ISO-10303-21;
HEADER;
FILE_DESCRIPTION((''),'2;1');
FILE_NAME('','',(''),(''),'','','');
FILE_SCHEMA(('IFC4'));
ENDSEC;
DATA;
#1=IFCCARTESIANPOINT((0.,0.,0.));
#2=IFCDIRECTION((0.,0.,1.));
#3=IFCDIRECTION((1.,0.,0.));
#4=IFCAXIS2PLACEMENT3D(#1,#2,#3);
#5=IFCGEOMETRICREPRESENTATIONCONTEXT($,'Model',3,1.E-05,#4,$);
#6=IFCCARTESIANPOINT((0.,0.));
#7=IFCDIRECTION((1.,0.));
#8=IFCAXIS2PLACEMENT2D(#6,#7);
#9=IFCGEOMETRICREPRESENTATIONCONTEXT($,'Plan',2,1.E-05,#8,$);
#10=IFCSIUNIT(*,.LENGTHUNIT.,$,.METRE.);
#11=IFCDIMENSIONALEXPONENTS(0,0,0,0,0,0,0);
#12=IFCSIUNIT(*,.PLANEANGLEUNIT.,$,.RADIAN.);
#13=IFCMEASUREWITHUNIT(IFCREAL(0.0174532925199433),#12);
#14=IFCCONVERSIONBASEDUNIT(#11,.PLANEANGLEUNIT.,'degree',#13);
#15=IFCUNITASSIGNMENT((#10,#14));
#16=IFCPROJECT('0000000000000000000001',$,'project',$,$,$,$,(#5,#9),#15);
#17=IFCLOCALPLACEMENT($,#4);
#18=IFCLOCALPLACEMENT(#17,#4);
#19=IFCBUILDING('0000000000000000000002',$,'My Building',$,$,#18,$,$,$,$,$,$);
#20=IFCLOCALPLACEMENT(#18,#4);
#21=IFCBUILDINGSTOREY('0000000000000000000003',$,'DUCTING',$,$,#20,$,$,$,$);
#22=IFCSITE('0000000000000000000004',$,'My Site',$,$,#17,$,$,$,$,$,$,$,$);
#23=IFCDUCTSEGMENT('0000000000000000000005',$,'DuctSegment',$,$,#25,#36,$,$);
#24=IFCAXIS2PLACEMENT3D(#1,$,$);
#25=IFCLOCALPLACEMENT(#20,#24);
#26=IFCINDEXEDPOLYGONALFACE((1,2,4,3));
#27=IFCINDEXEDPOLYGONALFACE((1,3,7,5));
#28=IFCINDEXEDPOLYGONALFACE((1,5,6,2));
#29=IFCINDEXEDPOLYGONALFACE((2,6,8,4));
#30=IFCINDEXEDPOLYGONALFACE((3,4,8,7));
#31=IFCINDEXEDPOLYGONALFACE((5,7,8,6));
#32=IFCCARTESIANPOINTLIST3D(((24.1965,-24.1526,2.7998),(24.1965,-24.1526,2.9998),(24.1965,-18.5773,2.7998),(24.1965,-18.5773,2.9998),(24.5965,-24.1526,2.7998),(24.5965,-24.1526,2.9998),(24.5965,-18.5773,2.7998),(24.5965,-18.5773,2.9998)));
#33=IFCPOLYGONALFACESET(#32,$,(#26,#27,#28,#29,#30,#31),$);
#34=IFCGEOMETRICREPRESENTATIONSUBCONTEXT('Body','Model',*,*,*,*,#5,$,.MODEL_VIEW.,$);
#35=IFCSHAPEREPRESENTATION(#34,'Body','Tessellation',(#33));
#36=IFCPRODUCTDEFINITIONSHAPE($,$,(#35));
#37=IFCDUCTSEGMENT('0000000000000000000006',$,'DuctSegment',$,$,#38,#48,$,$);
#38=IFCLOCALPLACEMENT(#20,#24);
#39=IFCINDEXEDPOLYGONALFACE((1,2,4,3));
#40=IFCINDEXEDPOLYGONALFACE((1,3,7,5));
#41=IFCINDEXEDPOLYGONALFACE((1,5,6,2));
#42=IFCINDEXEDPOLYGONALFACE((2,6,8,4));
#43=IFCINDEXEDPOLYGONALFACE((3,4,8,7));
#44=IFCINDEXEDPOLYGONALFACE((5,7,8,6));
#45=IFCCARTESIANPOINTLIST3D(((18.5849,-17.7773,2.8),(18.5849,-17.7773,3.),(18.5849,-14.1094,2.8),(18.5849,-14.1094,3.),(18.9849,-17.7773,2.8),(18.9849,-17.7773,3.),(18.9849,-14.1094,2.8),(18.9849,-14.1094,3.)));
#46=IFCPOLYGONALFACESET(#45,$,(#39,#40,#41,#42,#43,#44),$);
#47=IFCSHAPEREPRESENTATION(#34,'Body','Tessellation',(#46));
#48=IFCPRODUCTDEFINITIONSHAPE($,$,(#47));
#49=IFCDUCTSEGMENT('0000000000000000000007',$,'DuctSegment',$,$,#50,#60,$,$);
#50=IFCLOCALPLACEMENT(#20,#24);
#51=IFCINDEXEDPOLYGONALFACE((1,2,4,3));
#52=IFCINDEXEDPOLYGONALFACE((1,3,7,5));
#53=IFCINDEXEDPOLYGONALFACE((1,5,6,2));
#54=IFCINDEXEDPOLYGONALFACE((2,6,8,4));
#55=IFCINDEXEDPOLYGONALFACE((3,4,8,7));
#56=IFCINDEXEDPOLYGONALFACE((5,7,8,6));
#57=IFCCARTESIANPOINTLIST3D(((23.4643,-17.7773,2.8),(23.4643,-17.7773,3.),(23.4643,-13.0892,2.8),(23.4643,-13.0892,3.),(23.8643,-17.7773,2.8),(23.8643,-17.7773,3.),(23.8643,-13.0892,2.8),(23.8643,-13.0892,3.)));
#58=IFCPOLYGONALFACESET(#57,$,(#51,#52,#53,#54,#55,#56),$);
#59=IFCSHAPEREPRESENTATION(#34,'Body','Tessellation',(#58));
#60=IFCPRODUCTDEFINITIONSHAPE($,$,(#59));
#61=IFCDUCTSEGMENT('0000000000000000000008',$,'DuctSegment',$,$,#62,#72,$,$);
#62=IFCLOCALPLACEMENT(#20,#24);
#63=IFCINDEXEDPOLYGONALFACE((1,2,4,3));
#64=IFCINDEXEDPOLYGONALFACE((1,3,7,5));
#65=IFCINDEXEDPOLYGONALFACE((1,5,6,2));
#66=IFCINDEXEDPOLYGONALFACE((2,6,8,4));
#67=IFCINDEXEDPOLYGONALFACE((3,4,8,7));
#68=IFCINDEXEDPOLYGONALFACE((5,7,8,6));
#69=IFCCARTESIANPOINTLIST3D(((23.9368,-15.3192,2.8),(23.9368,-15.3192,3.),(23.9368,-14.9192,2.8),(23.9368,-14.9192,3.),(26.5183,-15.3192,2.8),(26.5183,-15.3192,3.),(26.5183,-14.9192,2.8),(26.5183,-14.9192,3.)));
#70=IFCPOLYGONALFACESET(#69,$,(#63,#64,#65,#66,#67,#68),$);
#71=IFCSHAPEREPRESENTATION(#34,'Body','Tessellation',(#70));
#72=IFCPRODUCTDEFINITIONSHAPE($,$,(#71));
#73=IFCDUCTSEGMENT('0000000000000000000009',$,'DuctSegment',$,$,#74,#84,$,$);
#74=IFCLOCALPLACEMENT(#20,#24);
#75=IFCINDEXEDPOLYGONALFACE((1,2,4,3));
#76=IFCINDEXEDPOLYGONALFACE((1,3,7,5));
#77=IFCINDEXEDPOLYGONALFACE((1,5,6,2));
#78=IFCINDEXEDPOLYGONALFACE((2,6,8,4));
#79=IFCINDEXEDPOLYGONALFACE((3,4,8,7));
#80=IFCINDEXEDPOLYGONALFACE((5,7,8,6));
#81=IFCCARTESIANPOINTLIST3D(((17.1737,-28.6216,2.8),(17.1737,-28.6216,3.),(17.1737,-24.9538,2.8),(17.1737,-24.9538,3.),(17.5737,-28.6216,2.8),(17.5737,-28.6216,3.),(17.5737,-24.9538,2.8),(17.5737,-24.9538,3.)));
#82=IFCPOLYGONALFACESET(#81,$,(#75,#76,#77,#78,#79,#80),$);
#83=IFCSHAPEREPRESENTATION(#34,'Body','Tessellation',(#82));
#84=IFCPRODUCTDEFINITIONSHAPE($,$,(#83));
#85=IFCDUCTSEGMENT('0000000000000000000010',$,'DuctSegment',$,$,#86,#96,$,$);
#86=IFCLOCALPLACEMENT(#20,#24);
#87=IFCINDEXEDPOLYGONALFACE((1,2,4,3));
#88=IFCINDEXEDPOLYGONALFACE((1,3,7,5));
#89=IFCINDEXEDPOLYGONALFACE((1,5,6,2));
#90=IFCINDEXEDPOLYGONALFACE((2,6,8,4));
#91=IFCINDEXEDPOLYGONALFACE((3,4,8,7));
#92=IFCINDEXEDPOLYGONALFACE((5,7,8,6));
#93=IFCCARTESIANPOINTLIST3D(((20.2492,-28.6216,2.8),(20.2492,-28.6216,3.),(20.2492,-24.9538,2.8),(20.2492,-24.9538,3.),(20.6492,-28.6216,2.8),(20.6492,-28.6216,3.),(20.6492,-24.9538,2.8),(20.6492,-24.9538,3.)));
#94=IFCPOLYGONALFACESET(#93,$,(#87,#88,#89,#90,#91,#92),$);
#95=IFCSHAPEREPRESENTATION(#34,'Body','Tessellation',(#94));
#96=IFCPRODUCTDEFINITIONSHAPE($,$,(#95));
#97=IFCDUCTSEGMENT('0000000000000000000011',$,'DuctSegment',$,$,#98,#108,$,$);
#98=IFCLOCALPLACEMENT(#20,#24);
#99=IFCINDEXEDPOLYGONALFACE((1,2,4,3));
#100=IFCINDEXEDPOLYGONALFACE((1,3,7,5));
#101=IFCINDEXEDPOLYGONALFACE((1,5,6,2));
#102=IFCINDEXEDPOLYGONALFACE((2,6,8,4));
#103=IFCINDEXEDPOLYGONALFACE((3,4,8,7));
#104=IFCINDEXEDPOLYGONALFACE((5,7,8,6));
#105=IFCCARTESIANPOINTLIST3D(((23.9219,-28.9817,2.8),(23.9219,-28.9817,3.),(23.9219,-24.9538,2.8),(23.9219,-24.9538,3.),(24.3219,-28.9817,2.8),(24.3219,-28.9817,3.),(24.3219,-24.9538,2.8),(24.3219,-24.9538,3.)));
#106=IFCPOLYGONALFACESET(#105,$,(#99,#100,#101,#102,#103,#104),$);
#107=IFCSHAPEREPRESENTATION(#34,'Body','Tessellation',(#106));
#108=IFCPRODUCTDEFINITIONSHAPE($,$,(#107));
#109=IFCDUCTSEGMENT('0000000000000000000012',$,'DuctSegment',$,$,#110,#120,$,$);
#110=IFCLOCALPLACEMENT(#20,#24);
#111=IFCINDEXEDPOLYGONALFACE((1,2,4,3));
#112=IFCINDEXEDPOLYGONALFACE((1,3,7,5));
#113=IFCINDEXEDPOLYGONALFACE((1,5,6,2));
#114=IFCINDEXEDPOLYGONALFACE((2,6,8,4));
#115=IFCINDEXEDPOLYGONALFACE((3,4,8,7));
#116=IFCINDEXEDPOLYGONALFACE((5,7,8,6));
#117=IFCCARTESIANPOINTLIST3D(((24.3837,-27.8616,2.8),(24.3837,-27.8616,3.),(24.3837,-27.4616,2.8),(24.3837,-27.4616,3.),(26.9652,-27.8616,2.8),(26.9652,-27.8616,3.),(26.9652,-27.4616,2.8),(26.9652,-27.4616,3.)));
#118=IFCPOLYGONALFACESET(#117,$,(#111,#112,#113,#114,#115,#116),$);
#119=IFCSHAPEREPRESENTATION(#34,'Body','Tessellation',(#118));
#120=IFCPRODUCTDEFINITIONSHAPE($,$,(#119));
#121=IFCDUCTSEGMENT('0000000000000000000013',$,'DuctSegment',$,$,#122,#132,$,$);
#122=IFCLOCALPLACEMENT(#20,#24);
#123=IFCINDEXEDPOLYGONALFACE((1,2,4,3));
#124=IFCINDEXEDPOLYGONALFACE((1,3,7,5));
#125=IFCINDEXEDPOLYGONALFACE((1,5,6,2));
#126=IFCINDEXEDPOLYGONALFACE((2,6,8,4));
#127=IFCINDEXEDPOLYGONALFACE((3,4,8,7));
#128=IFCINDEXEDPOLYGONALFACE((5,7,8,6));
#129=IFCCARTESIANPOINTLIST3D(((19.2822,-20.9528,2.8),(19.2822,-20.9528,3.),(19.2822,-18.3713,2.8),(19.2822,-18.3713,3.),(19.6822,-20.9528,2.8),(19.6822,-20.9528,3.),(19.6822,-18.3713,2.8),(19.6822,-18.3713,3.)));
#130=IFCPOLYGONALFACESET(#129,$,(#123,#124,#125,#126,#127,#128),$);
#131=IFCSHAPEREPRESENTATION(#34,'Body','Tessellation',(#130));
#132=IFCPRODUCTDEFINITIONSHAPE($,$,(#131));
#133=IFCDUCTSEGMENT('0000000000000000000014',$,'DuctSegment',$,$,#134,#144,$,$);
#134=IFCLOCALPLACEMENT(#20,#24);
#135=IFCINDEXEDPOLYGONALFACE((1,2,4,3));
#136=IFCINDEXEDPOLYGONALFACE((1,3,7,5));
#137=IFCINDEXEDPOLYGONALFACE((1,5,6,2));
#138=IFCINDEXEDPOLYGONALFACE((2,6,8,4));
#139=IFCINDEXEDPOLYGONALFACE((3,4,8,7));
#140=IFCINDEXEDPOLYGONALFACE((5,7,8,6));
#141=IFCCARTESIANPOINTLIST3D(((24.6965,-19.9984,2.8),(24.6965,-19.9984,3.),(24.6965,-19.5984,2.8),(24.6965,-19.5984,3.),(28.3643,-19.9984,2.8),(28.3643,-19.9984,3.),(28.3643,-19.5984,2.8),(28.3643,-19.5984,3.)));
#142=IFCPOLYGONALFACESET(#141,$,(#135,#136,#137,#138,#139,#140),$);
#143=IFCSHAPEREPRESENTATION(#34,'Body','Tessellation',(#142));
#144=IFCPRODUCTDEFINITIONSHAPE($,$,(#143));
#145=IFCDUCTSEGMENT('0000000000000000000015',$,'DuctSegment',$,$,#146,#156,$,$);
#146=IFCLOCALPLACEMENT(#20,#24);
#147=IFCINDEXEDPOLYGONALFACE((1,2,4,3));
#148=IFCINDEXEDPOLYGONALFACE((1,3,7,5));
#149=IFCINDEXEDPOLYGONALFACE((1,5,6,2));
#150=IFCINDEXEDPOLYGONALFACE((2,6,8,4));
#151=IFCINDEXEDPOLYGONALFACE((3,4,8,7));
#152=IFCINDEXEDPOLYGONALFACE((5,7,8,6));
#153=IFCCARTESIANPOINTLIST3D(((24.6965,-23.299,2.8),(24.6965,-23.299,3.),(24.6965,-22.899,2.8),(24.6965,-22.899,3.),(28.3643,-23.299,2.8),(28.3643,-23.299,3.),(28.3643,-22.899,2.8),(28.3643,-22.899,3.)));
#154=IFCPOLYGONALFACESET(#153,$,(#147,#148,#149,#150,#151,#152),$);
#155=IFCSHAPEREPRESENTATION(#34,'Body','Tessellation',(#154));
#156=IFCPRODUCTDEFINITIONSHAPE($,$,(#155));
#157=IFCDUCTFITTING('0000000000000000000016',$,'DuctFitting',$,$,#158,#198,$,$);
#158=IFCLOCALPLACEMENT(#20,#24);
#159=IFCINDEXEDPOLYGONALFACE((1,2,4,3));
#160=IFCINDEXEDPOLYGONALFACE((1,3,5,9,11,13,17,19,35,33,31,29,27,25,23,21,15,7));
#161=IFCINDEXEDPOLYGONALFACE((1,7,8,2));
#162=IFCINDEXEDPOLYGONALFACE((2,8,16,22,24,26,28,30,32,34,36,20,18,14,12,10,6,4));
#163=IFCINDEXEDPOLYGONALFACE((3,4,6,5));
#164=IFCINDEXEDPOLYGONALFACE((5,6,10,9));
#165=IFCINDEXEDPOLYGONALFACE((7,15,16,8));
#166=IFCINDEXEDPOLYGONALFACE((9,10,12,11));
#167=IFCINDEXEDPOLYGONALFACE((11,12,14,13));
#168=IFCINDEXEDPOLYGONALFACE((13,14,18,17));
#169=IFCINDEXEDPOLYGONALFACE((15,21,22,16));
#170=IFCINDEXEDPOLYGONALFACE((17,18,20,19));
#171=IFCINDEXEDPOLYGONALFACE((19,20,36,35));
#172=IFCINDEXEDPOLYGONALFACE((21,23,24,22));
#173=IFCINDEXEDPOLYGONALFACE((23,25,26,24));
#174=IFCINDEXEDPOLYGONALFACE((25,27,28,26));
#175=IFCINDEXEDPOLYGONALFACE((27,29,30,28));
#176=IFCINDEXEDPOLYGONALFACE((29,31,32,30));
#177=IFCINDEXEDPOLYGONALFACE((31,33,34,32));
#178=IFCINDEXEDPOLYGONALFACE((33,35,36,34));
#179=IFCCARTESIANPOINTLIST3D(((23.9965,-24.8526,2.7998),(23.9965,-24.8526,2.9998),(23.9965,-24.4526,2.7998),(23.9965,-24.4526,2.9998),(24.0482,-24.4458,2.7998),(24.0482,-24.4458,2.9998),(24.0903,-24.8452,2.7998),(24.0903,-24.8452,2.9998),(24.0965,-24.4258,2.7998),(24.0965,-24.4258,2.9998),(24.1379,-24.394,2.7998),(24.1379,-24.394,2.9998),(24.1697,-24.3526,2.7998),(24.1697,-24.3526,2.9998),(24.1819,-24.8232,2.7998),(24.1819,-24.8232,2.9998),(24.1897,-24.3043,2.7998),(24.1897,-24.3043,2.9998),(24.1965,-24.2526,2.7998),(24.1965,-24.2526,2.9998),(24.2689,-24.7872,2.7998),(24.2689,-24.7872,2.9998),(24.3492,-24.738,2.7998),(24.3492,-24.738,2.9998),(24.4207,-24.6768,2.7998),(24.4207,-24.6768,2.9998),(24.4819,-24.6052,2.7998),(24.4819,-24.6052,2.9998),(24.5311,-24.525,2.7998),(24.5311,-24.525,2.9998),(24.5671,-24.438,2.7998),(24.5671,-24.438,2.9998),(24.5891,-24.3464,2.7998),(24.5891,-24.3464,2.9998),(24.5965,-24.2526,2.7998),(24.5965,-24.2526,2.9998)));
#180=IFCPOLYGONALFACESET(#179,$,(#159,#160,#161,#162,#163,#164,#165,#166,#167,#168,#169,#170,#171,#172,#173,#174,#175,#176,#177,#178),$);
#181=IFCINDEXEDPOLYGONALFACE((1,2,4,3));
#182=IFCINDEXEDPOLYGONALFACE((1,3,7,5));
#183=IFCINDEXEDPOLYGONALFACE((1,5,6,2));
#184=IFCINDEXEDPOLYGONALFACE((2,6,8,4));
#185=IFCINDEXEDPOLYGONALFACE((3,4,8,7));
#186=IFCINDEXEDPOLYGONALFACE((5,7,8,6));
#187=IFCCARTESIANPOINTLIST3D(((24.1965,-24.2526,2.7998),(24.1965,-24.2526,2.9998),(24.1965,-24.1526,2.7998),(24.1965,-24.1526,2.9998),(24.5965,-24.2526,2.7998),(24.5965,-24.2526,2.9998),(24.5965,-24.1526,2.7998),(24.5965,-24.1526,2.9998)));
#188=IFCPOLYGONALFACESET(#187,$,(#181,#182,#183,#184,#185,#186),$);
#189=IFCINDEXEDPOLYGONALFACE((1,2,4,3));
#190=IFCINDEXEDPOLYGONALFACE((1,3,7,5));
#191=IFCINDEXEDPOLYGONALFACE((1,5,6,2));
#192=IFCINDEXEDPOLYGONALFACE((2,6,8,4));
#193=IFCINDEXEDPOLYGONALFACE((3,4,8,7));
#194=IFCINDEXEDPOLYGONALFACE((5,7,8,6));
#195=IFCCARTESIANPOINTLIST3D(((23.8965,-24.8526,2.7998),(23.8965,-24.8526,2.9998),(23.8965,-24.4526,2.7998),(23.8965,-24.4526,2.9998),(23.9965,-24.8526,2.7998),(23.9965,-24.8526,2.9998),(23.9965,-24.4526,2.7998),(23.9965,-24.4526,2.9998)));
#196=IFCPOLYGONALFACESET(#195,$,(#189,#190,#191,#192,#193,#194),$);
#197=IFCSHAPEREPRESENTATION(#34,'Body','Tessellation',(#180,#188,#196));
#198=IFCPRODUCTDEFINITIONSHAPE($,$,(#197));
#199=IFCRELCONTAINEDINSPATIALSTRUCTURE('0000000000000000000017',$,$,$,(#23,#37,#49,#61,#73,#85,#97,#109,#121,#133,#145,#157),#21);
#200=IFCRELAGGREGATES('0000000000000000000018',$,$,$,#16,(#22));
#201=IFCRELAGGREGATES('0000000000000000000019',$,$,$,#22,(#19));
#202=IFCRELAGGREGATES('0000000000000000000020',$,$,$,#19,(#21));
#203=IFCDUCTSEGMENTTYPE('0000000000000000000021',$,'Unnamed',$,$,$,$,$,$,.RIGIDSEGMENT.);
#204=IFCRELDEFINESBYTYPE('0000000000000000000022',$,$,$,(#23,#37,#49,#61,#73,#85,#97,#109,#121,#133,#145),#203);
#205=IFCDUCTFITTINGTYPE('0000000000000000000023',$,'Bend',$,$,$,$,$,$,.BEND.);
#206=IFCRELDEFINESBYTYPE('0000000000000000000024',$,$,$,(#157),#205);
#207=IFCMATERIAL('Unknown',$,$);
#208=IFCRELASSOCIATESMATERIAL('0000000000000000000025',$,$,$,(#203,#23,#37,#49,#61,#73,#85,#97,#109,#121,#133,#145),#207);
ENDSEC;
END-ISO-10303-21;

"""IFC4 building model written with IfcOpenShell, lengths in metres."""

from ifc_helpers import new_model, entity, si_unit, converted_unit, frame, origin_with_axes, origin_2d_with_axis, place, context, subcontext, project, spatial, line, arc, indexed_curve, rectangle, outline, extrude, source, transform, mapped, material, material_profile, profile_set, profile_usage, type_object, type_shapes, element, save


model = new_model("IFC4")

# Units and contexts
model_context = context("Model", 3, precision=1e-05, world=origin_with_axes())
plan_context = context("Plan", 2, precision=1e-05, world=origin_2d_with_axis())
body_context = subcontext(model_context, "Body", "Model", "MODEL_VIEW")
ifc_project = project(units=[si_unit("LENGTHUNIT", "METRE"), converted_unit("PLANEANGLEUNIT", "degree", entity("IfcReal", 0.0174532925199433), si_unit("PLANEANGLEUNIT", "RADIAN"), dimensions=[0, 0, 0, 0, 0, 0, 0])], contexts=[model_context, plan_context])

# Site, building, storey
site_placement = place(None, origin_with_axes())
site = spatial("IfcSite", under=ifc_project, at=site_placement, Name="My Site")
building_placement = place(site_placement, origin_with_axes())
building = spatial("IfcBuilding", under=site, at=building_placement, Name="My Building")
storey_placement = place(building_placement, origin_with_axes())
storey = spatial("IfcBuildingStorey", under=building, at=storey_placement, Name="DUCTING")

# Duct segments
ifc_material = material(Name="Unknown")
ifc_material_profile_1 = material_profile(ifc_material, rectangle(XDim=0.4, YDim=0.2))
ifc_profile_set_1 = profile_set([ifc_material_profile_1])
ifc_profile_usage_1 = profile_usage(ifc_profile_set_1, cardinal=5)
duct_segment_type = type_object("IfcDuctSegmentType", Name="Unnamed", PredefinedType="RIGIDSEGMENT", material=ifc_profile_set_1)
duct_segment_1_placement = place(storey_placement, frame((24.3965, -18.5773, 2.8998), z_axis=(0.0, -1.0, 0.0), x_axis=(1.0, 0.0, 0.0)))
element("IfcDuctSegment", 1, at=duct_segment_1_placement, inside=storey, type_object=duct_segment_type, material=ifc_profile_usage_1, Name="DuctSegment", context=body_context, shape_type="SweptSolid", body=[
    extrude(rectangle(XDim=0.4, YDim=0.2), origin_with_axes(), (0.0, 0.0, 1.0), 5.5753),
])
ifc_profile_usage_2 = profile_usage(ifc_profile_set_1, cardinal=5)
duct_segment_2_placement = place(storey_placement, frame((18.7849, -17.7773, 2.9), z_axis=(0.0, 1.0, 0.0), x_axis=(-1.0, 0.0, 0.0)))
element("IfcDuctSegment", 2, at=duct_segment_2_placement, inside=storey, type_object=duct_segment_type, material=ifc_profile_usage_2, Name="DuctSegment", context=body_context, shape_type="SweptSolid", body=[
    extrude(rectangle(XDim=0.4, YDim=0.2), origin_with_axes(), (0.0, 0.0, 1.0), 3.6678),
])
ifc_profile_usage_3 = profile_usage(ifc_profile_set_1, cardinal=5)
duct_segment_3_placement = place(storey_placement, frame((23.6643, -17.7773, 2.9), z_axis=(0.0, 1.0, 0.0), x_axis=(-1.0, 0.0, 0.0)))
element("IfcDuctSegment", 3, at=duct_segment_3_placement, inside=storey, type_object=duct_segment_type, material=ifc_profile_usage_3, Name="DuctSegment", context=body_context, shape_type="SweptSolid", body=[
    extrude(rectangle(XDim=0.4, YDim=0.2), origin_with_axes(), (0.0, 0.0, 1.0), 4.688),
])
ifc_profile_usage_4 = profile_usage(ifc_profile_set_1, cardinal=5)
duct_segment_4_placement = place(storey_placement, frame((23.9368, -15.1192, 2.9), z_axis=(1.0, 0.0, 0.0), x_axis=(0.0, 1.0, 0.0)))
element("IfcDuctSegment", 4, at=duct_segment_4_placement, inside=storey, type_object=duct_segment_type, material=ifc_profile_usage_4, Name="DuctSegment", context=body_context, shape_type="SweptSolid", body=[
    extrude(rectangle(XDim=0.4, YDim=0.2), origin_with_axes(), (0.0, 0.0, 1.0), 2.5815),
])
ifc_profile_usage_5 = profile_usage(ifc_profile_set_1, cardinal=5)
duct_segment_5_placement = place(storey_placement, frame((17.3737, -24.9538, 2.9), z_axis=(0.0, -1.0, 0.0), x_axis=(1.0, 0.0, 0.0)))
element("IfcDuctSegment", 5, at=duct_segment_5_placement, inside=storey, type_object=duct_segment_type, material=ifc_profile_usage_5, Name="DuctSegment", context=body_context, shape_type="SweptSolid", body=[
    extrude(rectangle(XDim=0.4, YDim=0.2), origin_with_axes(), (0.0, 0.0, 1.0), 3.6678),
])
ifc_profile_usage_6 = profile_usage(ifc_profile_set_1, cardinal=5)
duct_segment_6_placement = place(storey_placement, frame((20.4492, -24.9538, 2.9), z_axis=(0.0, -1.0, 0.0), x_axis=(1.0, 0.0, 0.0)))
element("IfcDuctSegment", 6, at=duct_segment_6_placement, inside=storey, type_object=duct_segment_type, material=ifc_profile_usage_6, Name="DuctSegment", context=body_context, shape_type="SweptSolid", body=[
    extrude(rectangle(XDim=0.4, YDim=0.2), origin_with_axes(), (0.0, 0.0, 1.0), 3.6678),
])
ifc_profile_usage_7 = profile_usage(ifc_profile_set_1, cardinal=5)
duct_segment_7_placement = place(storey_placement, frame((24.1219, -24.9538, 2.9), z_axis=(0.0, -1.0, 0.0), x_axis=(1.0, 0.0, 0.0)))
element("IfcDuctSegment", 7, at=duct_segment_7_placement, inside=storey, type_object=duct_segment_type, material=ifc_profile_usage_7, Name="DuctSegment", context=body_context, shape_type="SweptSolid", body=[
    extrude(rectangle(XDim=0.4, YDim=0.2), origin_with_axes(), (0.0, 0.0, 1.0), 4.0279),
])
ifc_profile_usage_8 = profile_usage(ifc_profile_set_1, cardinal=5)
duct_segment_8_placement = place(storey_placement, frame((24.3837, -27.6616, 2.9), z_axis=(1.0, 0.0, 0.0), x_axis=(0.0, 1.0, 0.0)))
element("IfcDuctSegment", 8, at=duct_segment_8_placement, inside=storey, type_object=duct_segment_type, material=ifc_profile_usage_8, Name="DuctSegment", context=body_context, shape_type="SweptSolid", body=[
    extrude(rectangle(XDim=0.4, YDim=0.2), origin_with_axes(), (0.0, 0.0, 1.0), 2.5815),
])
ifc_profile_usage_9 = profile_usage(ifc_profile_set_1, cardinal=5)
duct_segment_9_placement = place(storey_placement, frame((19.4822, -18.3713, 2.9), z_axis=(0.0, -1.0, 0.0), x_axis=(1.0, 0.0, 0.0)))
element("IfcDuctSegment", 9, at=duct_segment_9_placement, inside=storey, type_object=duct_segment_type, material=ifc_profile_usage_9, Name="DuctSegment", context=body_context, shape_type="SweptSolid", body=[
    extrude(rectangle(XDim=0.4, YDim=0.2), origin_with_axes(), (0.0, 0.0, 1.0), 2.5815),
])
ifc_profile_usage_10 = profile_usage(ifc_profile_set_1, cardinal=5)
duct_segment_10_placement = place(storey_placement, frame((24.6965, -19.7984, 2.9), z_axis=(1.0, 0.0, 0.0), x_axis=(0.0, 1.0, 0.0)))
element("IfcDuctSegment", 10, at=duct_segment_10_placement, inside=storey, type_object=duct_segment_type, material=ifc_profile_usage_10, Name="DuctSegment", context=body_context, shape_type="SweptSolid", body=[
    extrude(rectangle(XDim=0.4, YDim=0.2), origin_with_axes(), (0.0, 0.0, 1.0), 3.6678),
])
ifc_profile_usage_11 = profile_usage(ifc_profile_set_1, cardinal=5)
duct_segment_11_placement = place(storey_placement, frame((24.6965, -23.099, 2.9), z_axis=(1.0, 0.0, 0.0), x_axis=(0.0, 1.0, 0.0)))
element("IfcDuctSegment", 11, at=duct_segment_11_placement, inside=storey, type_object=duct_segment_type, material=ifc_profile_usage_11, Name="DuctSegment", context=body_context, shape_type="SweptSolid", body=[
    extrude(rectangle(XDim=0.4, YDim=0.2), origin_with_axes(), (0.0, 0.0, 1.0), 3.6678),
])

# Duct fitting
duct_fitting_type_1 = type_object("IfcDuctFittingType", Name="Bend", PredefinedType="BEND")
shared_shape = source(origin_with_axes(), body_context, "Body", "SweptSolid", [
    extrude(outline(indexed_curve([(-0.2, 0.0), (-0.2586, 0.1414), (-0.4, 0.2), (-0.4, 0.6), (0.0243, 0.4243), (0.2, 0.0)], segments=[arc(1, 2, 3), line(3, 4), arc(4, 5, 6), line(6, 1)])), frame((0.0, -0.1, 0.1), z_axis=(0.0, -1.0, 0.0), x_axis=(1.0, 0.0, 0.0)), (0.0, 0.0, -1.0), 0.2),
    extrude(rectangle(XDim=0.4, YDim=0.2), origin_with_axes(), (0.0, 0.0, 1.0), 0.1),
    extrude(rectangle(XDim=0.4, YDim=0.2), frame((-0.4, 0.0, 0.5), z_axis=(-1.0, 0.0, 0.0), x_axis=(0.0, 0.0, -1.0)), (0.0, 0.0, 1.0), 0.1),
])
type_shapes(duct_fitting_type_1, [shared_shape])
for number, where, z_axis, x_axis, name in (
    (12, (24.3965, -24.1526, 2.8998), (0.0, -1.0, 0.0), (1.0, 0.0, 0.0), "DuctFitting"),
):
    element("IfcDuctFitting", number, at=place(storey_placement, frame(where, z_axis=z_axis, x_axis=x_axis)), inside=storey, type_object=duct_fitting_type_1, Name=name, context=body_context, shape_type="MappedRepresentation", body=[
        mapped(shared_shape, transform((0.0, 0.0, 0.0), x_axis=(1.0, 0.0, 0.0), y_axis=(0.0, 1.0, 0.0), z_axis=(0.0, 0.0, 1.0), scale=1.0)),
    ])

save(model, "model.ifc")
